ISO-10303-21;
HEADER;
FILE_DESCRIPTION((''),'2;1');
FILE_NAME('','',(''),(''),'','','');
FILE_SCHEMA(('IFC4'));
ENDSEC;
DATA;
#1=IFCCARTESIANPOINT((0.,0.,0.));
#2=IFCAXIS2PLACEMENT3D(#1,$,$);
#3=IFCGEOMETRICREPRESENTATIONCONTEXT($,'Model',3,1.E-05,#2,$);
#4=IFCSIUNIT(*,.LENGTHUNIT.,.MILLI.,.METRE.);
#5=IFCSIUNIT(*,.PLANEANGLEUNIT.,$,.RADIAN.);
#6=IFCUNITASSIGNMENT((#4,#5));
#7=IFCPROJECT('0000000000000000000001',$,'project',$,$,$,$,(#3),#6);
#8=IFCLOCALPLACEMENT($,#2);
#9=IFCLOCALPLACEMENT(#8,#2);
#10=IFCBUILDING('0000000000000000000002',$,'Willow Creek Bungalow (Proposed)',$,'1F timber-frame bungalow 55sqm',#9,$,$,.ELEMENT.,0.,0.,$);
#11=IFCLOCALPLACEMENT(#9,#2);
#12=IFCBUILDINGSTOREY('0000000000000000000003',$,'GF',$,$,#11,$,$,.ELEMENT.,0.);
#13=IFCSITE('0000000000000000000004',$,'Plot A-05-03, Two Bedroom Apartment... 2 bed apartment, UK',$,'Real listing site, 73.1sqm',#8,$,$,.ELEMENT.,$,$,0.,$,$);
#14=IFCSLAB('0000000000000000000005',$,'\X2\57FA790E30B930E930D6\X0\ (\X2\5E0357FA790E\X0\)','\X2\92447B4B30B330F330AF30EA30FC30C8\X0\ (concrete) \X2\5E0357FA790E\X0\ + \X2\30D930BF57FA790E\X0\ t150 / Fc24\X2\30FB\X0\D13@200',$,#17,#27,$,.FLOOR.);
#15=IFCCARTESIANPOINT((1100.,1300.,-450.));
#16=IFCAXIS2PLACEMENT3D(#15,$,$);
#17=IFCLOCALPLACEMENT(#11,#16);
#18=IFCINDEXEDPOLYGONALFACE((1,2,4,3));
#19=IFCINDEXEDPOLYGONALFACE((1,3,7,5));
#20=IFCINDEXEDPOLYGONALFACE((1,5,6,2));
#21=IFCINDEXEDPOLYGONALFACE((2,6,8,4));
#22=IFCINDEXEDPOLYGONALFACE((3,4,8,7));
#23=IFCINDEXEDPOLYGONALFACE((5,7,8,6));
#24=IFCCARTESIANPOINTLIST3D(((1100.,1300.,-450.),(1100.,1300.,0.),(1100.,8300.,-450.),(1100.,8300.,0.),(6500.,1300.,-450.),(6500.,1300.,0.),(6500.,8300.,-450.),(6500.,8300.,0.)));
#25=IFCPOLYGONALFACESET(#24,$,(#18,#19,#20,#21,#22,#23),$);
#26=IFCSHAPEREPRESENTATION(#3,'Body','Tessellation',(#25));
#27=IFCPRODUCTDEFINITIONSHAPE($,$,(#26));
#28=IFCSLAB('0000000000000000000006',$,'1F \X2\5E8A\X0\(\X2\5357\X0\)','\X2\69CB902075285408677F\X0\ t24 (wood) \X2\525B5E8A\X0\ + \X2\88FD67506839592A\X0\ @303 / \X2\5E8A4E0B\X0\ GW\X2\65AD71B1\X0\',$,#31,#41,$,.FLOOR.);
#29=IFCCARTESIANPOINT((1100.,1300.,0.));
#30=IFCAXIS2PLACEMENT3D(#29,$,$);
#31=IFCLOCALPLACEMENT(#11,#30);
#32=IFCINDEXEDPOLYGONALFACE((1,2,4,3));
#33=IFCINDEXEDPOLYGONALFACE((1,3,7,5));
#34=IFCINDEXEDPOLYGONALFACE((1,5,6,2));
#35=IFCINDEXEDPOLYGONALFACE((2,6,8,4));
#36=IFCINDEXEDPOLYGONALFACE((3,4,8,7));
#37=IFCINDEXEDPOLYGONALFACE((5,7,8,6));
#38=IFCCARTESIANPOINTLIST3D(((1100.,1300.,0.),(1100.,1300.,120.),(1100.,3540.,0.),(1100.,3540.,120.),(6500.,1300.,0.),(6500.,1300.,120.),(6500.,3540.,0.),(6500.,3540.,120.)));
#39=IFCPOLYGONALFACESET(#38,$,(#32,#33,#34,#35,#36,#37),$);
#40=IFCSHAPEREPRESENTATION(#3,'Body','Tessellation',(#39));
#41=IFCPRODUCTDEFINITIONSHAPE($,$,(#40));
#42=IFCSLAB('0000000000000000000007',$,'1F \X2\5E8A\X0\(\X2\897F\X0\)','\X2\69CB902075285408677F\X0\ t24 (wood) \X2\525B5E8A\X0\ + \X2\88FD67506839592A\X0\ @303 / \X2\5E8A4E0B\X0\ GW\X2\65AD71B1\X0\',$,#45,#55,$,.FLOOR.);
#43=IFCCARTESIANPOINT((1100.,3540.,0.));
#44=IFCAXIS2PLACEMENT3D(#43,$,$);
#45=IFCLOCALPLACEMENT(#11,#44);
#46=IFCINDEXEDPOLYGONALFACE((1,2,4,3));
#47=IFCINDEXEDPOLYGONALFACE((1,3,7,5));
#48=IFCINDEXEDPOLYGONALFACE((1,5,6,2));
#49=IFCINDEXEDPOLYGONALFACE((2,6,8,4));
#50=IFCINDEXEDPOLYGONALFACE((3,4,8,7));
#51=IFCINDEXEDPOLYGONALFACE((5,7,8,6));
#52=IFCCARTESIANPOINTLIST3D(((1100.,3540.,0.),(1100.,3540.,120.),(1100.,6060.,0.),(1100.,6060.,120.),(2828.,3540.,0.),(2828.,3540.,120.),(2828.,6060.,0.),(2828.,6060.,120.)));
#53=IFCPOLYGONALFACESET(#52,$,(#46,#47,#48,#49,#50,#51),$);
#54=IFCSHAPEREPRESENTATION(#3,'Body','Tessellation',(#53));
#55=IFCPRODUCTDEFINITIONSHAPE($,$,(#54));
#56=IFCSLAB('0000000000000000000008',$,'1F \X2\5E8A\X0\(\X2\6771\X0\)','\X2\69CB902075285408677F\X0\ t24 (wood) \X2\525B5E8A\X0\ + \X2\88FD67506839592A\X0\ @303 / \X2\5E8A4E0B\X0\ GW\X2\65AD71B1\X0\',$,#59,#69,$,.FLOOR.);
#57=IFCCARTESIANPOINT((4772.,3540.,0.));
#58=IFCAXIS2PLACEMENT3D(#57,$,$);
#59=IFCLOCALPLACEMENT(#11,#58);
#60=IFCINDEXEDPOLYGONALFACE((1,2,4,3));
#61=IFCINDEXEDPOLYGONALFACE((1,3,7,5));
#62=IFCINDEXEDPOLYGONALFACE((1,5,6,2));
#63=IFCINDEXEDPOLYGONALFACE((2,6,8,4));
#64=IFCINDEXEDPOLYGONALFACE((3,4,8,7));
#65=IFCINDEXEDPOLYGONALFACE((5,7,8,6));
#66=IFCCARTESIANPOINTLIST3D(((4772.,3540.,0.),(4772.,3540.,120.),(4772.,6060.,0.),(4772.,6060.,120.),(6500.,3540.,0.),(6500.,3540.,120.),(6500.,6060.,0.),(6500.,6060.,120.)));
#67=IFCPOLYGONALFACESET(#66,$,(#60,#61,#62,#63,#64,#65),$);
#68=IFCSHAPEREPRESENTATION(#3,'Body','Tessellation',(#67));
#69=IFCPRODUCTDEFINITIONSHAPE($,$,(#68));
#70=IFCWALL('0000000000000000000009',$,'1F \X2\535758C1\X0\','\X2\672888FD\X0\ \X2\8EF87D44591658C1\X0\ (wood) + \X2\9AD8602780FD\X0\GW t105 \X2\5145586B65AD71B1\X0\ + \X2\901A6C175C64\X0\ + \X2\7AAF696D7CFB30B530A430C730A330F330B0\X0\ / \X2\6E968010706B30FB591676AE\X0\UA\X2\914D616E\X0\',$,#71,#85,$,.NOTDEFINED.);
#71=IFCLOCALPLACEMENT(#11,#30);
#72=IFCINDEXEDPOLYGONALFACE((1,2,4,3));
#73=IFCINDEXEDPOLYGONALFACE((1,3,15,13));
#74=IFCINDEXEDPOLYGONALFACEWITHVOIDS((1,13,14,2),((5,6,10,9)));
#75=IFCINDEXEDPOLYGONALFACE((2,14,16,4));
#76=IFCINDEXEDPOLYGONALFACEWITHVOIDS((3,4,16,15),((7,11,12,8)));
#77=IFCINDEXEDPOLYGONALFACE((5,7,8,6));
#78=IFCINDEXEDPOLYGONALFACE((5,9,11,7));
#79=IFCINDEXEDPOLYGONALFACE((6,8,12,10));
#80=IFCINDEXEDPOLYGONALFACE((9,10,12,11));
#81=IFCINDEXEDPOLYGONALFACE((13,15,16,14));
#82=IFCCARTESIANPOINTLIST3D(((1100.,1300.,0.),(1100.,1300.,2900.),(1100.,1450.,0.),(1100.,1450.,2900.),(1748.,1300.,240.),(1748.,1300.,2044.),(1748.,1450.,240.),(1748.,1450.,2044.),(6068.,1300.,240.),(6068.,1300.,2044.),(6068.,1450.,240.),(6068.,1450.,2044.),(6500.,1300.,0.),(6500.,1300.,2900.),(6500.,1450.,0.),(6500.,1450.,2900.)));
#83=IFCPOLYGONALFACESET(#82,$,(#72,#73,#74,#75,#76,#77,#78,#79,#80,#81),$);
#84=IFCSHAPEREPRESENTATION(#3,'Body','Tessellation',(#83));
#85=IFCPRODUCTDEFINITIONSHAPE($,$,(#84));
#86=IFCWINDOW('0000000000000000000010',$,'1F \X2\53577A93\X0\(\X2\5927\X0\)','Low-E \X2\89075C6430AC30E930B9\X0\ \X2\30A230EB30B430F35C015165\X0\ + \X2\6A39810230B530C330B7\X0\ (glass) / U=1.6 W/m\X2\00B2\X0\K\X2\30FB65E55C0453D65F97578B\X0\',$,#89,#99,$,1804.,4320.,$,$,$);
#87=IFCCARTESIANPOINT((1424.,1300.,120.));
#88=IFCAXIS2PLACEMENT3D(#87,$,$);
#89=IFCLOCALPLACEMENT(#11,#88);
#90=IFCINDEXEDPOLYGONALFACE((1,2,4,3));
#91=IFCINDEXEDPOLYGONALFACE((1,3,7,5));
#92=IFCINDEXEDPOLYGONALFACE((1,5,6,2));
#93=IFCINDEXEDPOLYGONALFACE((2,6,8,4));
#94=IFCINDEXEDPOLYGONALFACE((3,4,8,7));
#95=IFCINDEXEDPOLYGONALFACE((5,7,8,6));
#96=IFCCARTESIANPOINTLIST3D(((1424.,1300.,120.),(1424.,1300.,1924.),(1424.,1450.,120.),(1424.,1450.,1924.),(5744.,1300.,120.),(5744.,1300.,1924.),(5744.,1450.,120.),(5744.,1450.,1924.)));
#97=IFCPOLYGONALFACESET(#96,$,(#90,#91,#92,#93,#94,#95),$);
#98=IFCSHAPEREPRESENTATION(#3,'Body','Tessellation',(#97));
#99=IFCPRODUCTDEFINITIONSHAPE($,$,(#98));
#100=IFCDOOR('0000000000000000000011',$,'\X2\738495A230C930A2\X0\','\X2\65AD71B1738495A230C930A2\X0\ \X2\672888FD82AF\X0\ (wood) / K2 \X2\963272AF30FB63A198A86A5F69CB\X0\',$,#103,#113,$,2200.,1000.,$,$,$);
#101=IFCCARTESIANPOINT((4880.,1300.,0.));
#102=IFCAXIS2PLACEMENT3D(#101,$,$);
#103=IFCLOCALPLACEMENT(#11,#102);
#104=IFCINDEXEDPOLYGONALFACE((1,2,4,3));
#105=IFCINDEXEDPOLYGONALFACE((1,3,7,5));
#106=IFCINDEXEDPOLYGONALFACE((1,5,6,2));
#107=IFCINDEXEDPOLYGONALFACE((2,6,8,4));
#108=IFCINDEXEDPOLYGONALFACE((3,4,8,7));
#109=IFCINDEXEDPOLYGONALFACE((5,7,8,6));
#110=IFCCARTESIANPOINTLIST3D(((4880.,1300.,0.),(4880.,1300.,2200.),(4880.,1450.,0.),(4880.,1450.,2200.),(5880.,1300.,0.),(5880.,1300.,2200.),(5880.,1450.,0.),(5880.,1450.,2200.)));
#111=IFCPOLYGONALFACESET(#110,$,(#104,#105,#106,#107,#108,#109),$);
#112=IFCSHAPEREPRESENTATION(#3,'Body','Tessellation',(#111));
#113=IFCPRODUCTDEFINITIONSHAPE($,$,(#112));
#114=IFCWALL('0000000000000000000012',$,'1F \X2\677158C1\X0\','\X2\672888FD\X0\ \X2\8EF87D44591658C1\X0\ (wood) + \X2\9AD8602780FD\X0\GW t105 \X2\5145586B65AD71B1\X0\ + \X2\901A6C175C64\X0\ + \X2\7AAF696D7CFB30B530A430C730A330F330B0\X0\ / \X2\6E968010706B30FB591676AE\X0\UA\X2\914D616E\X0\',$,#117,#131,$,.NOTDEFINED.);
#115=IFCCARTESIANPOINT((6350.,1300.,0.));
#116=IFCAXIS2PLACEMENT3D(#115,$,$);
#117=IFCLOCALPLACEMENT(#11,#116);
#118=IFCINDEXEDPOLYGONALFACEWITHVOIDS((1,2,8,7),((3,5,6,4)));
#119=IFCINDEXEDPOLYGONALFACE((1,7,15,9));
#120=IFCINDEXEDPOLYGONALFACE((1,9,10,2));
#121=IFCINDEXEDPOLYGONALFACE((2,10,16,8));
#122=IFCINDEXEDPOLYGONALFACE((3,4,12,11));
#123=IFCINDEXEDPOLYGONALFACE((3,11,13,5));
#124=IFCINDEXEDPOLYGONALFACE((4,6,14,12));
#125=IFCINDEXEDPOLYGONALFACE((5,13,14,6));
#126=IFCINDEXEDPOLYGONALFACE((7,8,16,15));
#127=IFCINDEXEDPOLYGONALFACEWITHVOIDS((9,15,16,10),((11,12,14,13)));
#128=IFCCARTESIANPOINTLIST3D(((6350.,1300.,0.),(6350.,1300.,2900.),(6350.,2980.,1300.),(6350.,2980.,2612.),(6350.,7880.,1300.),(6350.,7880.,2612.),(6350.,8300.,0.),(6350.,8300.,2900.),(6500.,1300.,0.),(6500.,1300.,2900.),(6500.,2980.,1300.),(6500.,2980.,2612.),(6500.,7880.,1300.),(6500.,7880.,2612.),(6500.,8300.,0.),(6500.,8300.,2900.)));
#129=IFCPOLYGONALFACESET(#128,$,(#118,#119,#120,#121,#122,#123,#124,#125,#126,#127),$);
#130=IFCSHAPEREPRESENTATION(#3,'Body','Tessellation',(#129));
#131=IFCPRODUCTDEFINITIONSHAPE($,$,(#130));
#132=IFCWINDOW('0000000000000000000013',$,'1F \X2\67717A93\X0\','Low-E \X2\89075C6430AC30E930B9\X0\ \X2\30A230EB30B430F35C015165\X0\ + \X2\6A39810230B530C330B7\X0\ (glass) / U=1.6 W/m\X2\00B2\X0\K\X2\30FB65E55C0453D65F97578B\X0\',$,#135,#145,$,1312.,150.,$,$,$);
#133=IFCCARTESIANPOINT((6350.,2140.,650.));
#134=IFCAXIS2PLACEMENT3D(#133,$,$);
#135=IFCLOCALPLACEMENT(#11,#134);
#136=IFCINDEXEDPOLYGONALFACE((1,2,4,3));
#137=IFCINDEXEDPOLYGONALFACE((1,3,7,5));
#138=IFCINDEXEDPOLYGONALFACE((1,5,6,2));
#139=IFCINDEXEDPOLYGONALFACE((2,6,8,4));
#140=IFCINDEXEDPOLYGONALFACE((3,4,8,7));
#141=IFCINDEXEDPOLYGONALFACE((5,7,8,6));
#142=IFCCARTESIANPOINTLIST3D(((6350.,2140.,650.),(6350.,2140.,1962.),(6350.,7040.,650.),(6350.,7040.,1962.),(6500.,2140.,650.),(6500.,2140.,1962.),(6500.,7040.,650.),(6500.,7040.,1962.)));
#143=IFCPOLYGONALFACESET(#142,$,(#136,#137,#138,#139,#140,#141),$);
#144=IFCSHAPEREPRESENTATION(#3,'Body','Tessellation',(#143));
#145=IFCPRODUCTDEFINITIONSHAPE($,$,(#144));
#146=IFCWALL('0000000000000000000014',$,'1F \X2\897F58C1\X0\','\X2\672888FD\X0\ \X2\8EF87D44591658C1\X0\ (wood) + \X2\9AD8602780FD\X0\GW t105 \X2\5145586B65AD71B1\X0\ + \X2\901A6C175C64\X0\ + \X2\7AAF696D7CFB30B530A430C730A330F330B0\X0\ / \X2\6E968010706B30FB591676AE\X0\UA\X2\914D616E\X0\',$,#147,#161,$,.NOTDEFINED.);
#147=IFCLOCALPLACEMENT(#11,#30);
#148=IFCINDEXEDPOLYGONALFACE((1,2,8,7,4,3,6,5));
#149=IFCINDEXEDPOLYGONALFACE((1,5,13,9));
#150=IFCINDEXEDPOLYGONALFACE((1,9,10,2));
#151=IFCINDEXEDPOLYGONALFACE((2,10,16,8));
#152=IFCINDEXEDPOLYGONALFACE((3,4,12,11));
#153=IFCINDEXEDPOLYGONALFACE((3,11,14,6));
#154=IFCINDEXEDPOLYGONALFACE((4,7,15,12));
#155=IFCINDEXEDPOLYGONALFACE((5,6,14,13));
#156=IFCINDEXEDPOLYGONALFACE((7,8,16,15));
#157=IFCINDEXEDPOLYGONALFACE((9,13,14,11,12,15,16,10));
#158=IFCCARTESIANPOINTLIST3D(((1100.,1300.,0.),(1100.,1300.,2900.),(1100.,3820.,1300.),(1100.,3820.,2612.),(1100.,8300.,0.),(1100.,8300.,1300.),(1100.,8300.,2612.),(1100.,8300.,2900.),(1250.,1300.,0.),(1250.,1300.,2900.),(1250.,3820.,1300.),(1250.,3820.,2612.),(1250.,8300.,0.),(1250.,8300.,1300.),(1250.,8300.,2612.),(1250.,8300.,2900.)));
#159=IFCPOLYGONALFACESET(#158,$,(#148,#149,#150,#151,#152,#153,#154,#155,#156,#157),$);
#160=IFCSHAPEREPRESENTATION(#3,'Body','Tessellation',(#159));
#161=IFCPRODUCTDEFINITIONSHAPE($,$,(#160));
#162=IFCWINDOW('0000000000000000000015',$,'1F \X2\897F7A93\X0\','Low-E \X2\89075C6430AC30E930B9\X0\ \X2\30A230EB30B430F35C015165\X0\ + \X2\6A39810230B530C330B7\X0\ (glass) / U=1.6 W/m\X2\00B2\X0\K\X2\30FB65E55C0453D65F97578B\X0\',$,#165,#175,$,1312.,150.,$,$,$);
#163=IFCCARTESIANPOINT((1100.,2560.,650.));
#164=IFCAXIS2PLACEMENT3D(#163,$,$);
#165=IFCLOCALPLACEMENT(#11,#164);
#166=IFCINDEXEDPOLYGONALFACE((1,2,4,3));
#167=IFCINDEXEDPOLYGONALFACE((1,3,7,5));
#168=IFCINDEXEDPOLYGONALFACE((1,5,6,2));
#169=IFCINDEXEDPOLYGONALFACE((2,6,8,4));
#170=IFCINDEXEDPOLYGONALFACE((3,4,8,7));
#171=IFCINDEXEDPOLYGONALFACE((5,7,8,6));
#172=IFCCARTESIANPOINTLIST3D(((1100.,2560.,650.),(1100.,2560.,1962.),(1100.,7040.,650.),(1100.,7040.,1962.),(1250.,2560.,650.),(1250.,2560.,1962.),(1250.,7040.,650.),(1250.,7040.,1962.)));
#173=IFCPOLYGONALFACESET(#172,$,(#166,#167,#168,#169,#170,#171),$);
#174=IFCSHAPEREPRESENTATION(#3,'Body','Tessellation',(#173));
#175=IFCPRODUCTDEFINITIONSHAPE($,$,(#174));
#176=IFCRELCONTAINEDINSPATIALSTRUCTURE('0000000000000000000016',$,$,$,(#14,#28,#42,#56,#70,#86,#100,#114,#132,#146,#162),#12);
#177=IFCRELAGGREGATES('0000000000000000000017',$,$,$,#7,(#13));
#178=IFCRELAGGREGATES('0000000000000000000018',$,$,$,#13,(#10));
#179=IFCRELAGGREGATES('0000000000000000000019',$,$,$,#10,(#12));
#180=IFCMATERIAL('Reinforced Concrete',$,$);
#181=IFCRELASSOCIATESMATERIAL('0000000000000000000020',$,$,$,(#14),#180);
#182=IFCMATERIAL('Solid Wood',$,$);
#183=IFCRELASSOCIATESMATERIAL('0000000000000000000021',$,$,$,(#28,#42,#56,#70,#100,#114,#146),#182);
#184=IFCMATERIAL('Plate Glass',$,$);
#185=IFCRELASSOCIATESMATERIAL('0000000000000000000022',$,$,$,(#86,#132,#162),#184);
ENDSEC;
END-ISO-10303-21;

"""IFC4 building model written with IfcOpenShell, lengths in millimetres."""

from ifc_helpers import new_model, si_unit, frame, frame_2d, origin, place, context, project, spatial, rectangle, extrude, material, element, fill, save


model = new_model("IFC4")

# Units and contexts
model_context = context("Model", 3, precision=1e-05, world=origin())
ifc_project = project(units=[si_unit("LENGTHUNIT", "METRE", prefix="MILLI"), si_unit("PLANEANGLEUNIT", "RADIAN")], contexts=[model_context])

# Site, building, storey
site_placement = place(None, origin())
site = spatial("IfcSite", under=ifc_project, at=site_placement, Name="Plot A-05-03, Two Bedroom Apartment... 2 bed apartment, UK", ObjectType="Real listing site, 73.1sqm", CompositionType="ELEMENT", RefElevation=0.0)
building_placement = place(site_placement, origin())
building = spatial("IfcBuilding", under=site, at=building_placement, Name="Willow Creek Bungalow (Proposed)", ObjectType="1F timber-frame bungalow 55sqm", CompositionType="ELEMENT", ElevationOfRefHeight=0.0, ElevationOfTerrain=0.0)
storey_placement = place(building_placement, origin())
storey = spatial("IfcBuildingStorey", under=building, at=storey_placement, Name="GF", CompositionType="ELEMENT", Elevation=0.0)

# Slabs
ifc_material_1 = material(Name="Reinforced Concrete")
slab_1_placement = place(storey_placement, frame((1100.0, 1300.0, -450.0)))
element("IfcSlab", 1, at=slab_1_placement, inside=storey, material=ifc_material_1, Name="基礎スラブ (布基礎)", Description="鉄筋コンクリート (concrete) 布基礎 + ベタ基礎 t150 / Fc24・D13@200", PredefinedType="FLOOR", context=model_context, shape_type="SweptSolid", body=[
    extrude(rectangle(XDim=5400.0, YDim=7000.0, at=frame_2d((2700.0, 3500.0))), frame((1100.0, 1300.0, -450.0)), (0.0, 0.0, 1.0), 450.0),
])
ifc_material_2 = material(Name="Solid Wood")
slab_2_placement = place(storey_placement, frame((1100.0, 1300.0, 0.0)))
element("IfcSlab", 2, at=slab_2_placement, inside=storey, material=ifc_material_2, Name="1F 床(南)", Description="構造用合板 t24 (wood) 剛床 + 製材根太 @303 / 床下 GW断熱", PredefinedType="FLOOR", context=model_context, shape_type="SweptSolid", body=[
    extrude(rectangle(XDim=5400.0, YDim=2240.0, at=frame_2d((2700.0, 1120.0))), frame((1100.0, 1300.0, 0.0)), (0.0, 0.0, 1.0), 120.0),
])
slab_3_placement = place(storey_placement, frame((1100.0, 3540.0, 0.0)))
element("IfcSlab", 3, at=slab_3_placement, inside=storey, material=ifc_material_2, Name="1F 床(西)", Description="構造用合板 t24 (wood) 剛床 + 製材根太 @303 / 床下 GW断熱", PredefinedType="FLOOR", context=model_context, shape_type="SweptSolid", body=[
    extrude(rectangle(XDim=1728.0, YDim=2520.0, at=frame_2d((864.0, 1260.0))), frame((1100.0, 3540.0, 0.0)), (0.0, 0.0, 1.0), 120.0),
])
slab_4_placement = place(storey_placement, frame((4772.0, 3540.0, 0.0)))
element("IfcSlab", 4, at=slab_4_placement, inside=storey, material=ifc_material_2, Name="1F 床(東)", Description="構造用合板 t24 (wood) 剛床 + 製材根太 @303 / 床下 GW断熱", PredefinedType="FLOOR", context=model_context, shape_type="SweptSolid", body=[
    extrude(rectangle(XDim=1728.0, YDim=2520.0, at=frame_2d((864.0, 1260.0))), frame((4772.0, 3540.0, 0.0)), (0.0, 0.0, 1.0), 120.0),
])

# Wall, openings, window, door
wall_1_placement = place(storey_placement, frame((1100.0, 1300.0, 0.0)))
wall_1 = element("IfcWall", 5, at=wall_1_placement, inside=storey, material=ifc_material_2, Name="1F 南壁", Description="木製 軸組外壁 (wood) + 高性能GW t105 充填断熱 + 通気層 + 窯業系サイディング / 準耐火・外皮UA配慮", PredefinedType="NOTDEFINED", context=model_context, shape_type="SweptSolid", body=[
    extrude(rectangle(XDim=5400.0, YDim=150.0, at=frame_2d((2700.0, 75.0))), frame((1100.0, 1300.0, 0.0)), (0.0, 0.0, 1.0), 2900.0),
])
opening_1_placement = place(storey_placement, frame((1424.0, 1300.0, 120.0)))
opening_1 = element("IfcOpeningElement", 6, at=opening_1_placement, cuts=wall_1, PredefinedType="NOTDEFINED", context=model_context, shape_type="SweptSolid", body=[
    extrude(rectangle(XDim=4320.0, YDim=150.0, at=frame_2d((2160.0, 75.0))), frame((1424.0, 1300.0, 120.0)), (0.0, 0.0, 1.0), 1804.0),
])
opening_2_placement = place(storey_placement, frame((4880.0, 1300.0, 0.0)))
opening_2 = element("IfcOpeningElement", 7, at=opening_2_placement, cuts=wall_1, PredefinedType="NOTDEFINED", context=model_context, shape_type="SweptSolid", body=[
    extrude(rectangle(XDim=1000.0, YDim=150.0, at=frame_2d((500.0, 75.0))), frame((4880.0, 1300.0, 0.0)), (0.0, 0.0, 1.0), 2200.0),
])
ifc_material_3 = material(Name="Plate Glass")
window_1_placement = place(storey_placement, frame((1424.0, 1300.0, 120.0)))
window_1 = element("IfcWindow", 8, at=window_1_placement, inside=storey, material=ifc_material_3, Name="1F 南窓(大)", Description="Low-E 複層ガラス アルゴン封入 + 樹脂サッシ (glass) / U=1.6 W/m²K・日射取得型", OverallHeight=1804.0, OverallWidth=4320.0, context=model_context, shape_type="SweptSolid", body=[
    extrude(rectangle(XDim=4320.0, YDim=150.0, at=frame_2d((2160.0, 75.0))), frame((1424.0, 1300.0, 120.0)), (0.0, 0.0, 1.0), 1804.0),
])
fill(opening_1, window_1)
door_placement = place(storey_placement, frame((4880.0, 1300.0, 0.0)))
door = element("IfcDoor", 9, at=door_placement, inside=storey, material=ifc_material_2, Name="玄関ドア", Description="断熱玄関ドア 木製芯 (wood) / K2 防犯・採風機構", OverallHeight=2200.0, OverallWidth=1000.0, context=model_context, shape_type="SweptSolid", body=[
    extrude(rectangle(XDim=1000.0, YDim=150.0, at=frame_2d((500.0, 75.0))), frame((4880.0, 1300.0, 0.0)), (0.0, 0.0, 1.0), 2200.0),
])
fill(opening_2, door)

# Walls, openings, windows
wall_2_placement = place(storey_placement, frame((6350.0, 1300.0, 0.0)))
wall_2 = element("IfcWall", 10, at=wall_2_placement, inside=storey, material=ifc_material_2, Name="1F 東壁", Description="木製 軸組外壁 (wood) + 高性能GW t105 充填断熱 + 通気層 + 窯業系サイディング / 準耐火・外皮UA配慮", PredefinedType="NOTDEFINED", context=model_context, shape_type="SweptSolid", body=[
    extrude(rectangle(XDim=150.0, YDim=7000.0, at=frame_2d((75.0, 3500.0))), frame((6350.0, 1300.0, 0.0)), (0.0, 0.0, 1.0), 2900.0),
])
opening_3_placement = place(storey_placement, frame((6350.0, 2140.0, 650.0)))
opening_3 = element("IfcOpeningElement", 11, at=opening_3_placement, cuts=wall_2, PredefinedType="NOTDEFINED", context=model_context, shape_type="SweptSolid", body=[
    extrude(rectangle(XDim=150.0, YDim=4900.0, at=frame_2d((75.0, 2450.0))), frame((6350.0, 2140.0, 650.0)), (0.0, 0.0, 1.0), 1312.0),
])
window_2_placement = place(storey_placement, frame((6350.0, 2140.0, 650.0)))
window_2 = element("IfcWindow", 12, at=window_2_placement, inside=storey, material=ifc_material_3, Name="1F 東窓", Description="Low-E 複層ガラス アルゴン封入 + 樹脂サッシ (glass) / U=1.6 W/m²K・日射取得型", OverallHeight=1312.0, OverallWidth=150.0, context=model_context, shape_type="SweptSolid", body=[
    extrude(rectangle(XDim=150.0, YDim=4900.0, at=frame_2d((75.0, 2450.0))), frame((6350.0, 2140.0, 650.0)), (0.0, 0.0, 1.0), 1312.0),
])
fill(opening_3, window_2)
wall_3_placement = place(storey_placement, frame((1100.0, 1300.0, 0.0)))
wall_3 = element("IfcWall", 13, at=wall_3_placement, inside=storey, material=ifc_material_2, Name="1F 西壁", Description="木製 軸組外壁 (wood) + 高性能GW t105 充填断熱 + 通気層 + 窯業系サイディング / 準耐火・外皮UA配慮", PredefinedType="NOTDEFINED", context=model_context, shape_type="SweptSolid", body=[
    extrude(rectangle(XDim=150.0, YDim=7000.0, at=frame_2d((75.0, 3500.0))), frame((1100.0, 1300.0, 0.0)), (0.0, 0.0, 1.0), 2900.0),
])
opening_4_placement = place(storey_placement, frame((1100.0, 2560.0, 650.0)))
opening_4 = element("IfcOpeningElement", 14, at=opening_4_placement, cuts=wall_3, PredefinedType="NOTDEFINED", context=model_context, shape_type="SweptSolid", body=[
    extrude(rectangle(XDim=150.0, YDim=4480.0, at=frame_2d((75.0, 2240.0))), frame((1100.0, 2560.0, 650.0)), (0.0, 0.0, 1.0), 1312.0),
])
window_3_placement = place(storey_placement, frame((1100.0, 2560.0, 650.0)))
window_3 = element("IfcWindow", 15, at=window_3_placement, inside=storey, material=ifc_material_3, Name="1F 西窓", Description="Low-E 複層ガラス アルゴン封入 + 樹脂サッシ (glass) / U=1.6 W/m²K・日射取得型", OverallHeight=1312.0, OverallWidth=150.0, context=model_context, shape_type="SweptSolid", body=[
    extrude(rectangle(XDim=150.0, YDim=4480.0, at=frame_2d((75.0, 2240.0))), frame((1100.0, 2560.0, 650.0)), (0.0, 0.0, 1.0), 1312.0),
])
fill(opening_4, window_3)

save(model, "model.ifc")
